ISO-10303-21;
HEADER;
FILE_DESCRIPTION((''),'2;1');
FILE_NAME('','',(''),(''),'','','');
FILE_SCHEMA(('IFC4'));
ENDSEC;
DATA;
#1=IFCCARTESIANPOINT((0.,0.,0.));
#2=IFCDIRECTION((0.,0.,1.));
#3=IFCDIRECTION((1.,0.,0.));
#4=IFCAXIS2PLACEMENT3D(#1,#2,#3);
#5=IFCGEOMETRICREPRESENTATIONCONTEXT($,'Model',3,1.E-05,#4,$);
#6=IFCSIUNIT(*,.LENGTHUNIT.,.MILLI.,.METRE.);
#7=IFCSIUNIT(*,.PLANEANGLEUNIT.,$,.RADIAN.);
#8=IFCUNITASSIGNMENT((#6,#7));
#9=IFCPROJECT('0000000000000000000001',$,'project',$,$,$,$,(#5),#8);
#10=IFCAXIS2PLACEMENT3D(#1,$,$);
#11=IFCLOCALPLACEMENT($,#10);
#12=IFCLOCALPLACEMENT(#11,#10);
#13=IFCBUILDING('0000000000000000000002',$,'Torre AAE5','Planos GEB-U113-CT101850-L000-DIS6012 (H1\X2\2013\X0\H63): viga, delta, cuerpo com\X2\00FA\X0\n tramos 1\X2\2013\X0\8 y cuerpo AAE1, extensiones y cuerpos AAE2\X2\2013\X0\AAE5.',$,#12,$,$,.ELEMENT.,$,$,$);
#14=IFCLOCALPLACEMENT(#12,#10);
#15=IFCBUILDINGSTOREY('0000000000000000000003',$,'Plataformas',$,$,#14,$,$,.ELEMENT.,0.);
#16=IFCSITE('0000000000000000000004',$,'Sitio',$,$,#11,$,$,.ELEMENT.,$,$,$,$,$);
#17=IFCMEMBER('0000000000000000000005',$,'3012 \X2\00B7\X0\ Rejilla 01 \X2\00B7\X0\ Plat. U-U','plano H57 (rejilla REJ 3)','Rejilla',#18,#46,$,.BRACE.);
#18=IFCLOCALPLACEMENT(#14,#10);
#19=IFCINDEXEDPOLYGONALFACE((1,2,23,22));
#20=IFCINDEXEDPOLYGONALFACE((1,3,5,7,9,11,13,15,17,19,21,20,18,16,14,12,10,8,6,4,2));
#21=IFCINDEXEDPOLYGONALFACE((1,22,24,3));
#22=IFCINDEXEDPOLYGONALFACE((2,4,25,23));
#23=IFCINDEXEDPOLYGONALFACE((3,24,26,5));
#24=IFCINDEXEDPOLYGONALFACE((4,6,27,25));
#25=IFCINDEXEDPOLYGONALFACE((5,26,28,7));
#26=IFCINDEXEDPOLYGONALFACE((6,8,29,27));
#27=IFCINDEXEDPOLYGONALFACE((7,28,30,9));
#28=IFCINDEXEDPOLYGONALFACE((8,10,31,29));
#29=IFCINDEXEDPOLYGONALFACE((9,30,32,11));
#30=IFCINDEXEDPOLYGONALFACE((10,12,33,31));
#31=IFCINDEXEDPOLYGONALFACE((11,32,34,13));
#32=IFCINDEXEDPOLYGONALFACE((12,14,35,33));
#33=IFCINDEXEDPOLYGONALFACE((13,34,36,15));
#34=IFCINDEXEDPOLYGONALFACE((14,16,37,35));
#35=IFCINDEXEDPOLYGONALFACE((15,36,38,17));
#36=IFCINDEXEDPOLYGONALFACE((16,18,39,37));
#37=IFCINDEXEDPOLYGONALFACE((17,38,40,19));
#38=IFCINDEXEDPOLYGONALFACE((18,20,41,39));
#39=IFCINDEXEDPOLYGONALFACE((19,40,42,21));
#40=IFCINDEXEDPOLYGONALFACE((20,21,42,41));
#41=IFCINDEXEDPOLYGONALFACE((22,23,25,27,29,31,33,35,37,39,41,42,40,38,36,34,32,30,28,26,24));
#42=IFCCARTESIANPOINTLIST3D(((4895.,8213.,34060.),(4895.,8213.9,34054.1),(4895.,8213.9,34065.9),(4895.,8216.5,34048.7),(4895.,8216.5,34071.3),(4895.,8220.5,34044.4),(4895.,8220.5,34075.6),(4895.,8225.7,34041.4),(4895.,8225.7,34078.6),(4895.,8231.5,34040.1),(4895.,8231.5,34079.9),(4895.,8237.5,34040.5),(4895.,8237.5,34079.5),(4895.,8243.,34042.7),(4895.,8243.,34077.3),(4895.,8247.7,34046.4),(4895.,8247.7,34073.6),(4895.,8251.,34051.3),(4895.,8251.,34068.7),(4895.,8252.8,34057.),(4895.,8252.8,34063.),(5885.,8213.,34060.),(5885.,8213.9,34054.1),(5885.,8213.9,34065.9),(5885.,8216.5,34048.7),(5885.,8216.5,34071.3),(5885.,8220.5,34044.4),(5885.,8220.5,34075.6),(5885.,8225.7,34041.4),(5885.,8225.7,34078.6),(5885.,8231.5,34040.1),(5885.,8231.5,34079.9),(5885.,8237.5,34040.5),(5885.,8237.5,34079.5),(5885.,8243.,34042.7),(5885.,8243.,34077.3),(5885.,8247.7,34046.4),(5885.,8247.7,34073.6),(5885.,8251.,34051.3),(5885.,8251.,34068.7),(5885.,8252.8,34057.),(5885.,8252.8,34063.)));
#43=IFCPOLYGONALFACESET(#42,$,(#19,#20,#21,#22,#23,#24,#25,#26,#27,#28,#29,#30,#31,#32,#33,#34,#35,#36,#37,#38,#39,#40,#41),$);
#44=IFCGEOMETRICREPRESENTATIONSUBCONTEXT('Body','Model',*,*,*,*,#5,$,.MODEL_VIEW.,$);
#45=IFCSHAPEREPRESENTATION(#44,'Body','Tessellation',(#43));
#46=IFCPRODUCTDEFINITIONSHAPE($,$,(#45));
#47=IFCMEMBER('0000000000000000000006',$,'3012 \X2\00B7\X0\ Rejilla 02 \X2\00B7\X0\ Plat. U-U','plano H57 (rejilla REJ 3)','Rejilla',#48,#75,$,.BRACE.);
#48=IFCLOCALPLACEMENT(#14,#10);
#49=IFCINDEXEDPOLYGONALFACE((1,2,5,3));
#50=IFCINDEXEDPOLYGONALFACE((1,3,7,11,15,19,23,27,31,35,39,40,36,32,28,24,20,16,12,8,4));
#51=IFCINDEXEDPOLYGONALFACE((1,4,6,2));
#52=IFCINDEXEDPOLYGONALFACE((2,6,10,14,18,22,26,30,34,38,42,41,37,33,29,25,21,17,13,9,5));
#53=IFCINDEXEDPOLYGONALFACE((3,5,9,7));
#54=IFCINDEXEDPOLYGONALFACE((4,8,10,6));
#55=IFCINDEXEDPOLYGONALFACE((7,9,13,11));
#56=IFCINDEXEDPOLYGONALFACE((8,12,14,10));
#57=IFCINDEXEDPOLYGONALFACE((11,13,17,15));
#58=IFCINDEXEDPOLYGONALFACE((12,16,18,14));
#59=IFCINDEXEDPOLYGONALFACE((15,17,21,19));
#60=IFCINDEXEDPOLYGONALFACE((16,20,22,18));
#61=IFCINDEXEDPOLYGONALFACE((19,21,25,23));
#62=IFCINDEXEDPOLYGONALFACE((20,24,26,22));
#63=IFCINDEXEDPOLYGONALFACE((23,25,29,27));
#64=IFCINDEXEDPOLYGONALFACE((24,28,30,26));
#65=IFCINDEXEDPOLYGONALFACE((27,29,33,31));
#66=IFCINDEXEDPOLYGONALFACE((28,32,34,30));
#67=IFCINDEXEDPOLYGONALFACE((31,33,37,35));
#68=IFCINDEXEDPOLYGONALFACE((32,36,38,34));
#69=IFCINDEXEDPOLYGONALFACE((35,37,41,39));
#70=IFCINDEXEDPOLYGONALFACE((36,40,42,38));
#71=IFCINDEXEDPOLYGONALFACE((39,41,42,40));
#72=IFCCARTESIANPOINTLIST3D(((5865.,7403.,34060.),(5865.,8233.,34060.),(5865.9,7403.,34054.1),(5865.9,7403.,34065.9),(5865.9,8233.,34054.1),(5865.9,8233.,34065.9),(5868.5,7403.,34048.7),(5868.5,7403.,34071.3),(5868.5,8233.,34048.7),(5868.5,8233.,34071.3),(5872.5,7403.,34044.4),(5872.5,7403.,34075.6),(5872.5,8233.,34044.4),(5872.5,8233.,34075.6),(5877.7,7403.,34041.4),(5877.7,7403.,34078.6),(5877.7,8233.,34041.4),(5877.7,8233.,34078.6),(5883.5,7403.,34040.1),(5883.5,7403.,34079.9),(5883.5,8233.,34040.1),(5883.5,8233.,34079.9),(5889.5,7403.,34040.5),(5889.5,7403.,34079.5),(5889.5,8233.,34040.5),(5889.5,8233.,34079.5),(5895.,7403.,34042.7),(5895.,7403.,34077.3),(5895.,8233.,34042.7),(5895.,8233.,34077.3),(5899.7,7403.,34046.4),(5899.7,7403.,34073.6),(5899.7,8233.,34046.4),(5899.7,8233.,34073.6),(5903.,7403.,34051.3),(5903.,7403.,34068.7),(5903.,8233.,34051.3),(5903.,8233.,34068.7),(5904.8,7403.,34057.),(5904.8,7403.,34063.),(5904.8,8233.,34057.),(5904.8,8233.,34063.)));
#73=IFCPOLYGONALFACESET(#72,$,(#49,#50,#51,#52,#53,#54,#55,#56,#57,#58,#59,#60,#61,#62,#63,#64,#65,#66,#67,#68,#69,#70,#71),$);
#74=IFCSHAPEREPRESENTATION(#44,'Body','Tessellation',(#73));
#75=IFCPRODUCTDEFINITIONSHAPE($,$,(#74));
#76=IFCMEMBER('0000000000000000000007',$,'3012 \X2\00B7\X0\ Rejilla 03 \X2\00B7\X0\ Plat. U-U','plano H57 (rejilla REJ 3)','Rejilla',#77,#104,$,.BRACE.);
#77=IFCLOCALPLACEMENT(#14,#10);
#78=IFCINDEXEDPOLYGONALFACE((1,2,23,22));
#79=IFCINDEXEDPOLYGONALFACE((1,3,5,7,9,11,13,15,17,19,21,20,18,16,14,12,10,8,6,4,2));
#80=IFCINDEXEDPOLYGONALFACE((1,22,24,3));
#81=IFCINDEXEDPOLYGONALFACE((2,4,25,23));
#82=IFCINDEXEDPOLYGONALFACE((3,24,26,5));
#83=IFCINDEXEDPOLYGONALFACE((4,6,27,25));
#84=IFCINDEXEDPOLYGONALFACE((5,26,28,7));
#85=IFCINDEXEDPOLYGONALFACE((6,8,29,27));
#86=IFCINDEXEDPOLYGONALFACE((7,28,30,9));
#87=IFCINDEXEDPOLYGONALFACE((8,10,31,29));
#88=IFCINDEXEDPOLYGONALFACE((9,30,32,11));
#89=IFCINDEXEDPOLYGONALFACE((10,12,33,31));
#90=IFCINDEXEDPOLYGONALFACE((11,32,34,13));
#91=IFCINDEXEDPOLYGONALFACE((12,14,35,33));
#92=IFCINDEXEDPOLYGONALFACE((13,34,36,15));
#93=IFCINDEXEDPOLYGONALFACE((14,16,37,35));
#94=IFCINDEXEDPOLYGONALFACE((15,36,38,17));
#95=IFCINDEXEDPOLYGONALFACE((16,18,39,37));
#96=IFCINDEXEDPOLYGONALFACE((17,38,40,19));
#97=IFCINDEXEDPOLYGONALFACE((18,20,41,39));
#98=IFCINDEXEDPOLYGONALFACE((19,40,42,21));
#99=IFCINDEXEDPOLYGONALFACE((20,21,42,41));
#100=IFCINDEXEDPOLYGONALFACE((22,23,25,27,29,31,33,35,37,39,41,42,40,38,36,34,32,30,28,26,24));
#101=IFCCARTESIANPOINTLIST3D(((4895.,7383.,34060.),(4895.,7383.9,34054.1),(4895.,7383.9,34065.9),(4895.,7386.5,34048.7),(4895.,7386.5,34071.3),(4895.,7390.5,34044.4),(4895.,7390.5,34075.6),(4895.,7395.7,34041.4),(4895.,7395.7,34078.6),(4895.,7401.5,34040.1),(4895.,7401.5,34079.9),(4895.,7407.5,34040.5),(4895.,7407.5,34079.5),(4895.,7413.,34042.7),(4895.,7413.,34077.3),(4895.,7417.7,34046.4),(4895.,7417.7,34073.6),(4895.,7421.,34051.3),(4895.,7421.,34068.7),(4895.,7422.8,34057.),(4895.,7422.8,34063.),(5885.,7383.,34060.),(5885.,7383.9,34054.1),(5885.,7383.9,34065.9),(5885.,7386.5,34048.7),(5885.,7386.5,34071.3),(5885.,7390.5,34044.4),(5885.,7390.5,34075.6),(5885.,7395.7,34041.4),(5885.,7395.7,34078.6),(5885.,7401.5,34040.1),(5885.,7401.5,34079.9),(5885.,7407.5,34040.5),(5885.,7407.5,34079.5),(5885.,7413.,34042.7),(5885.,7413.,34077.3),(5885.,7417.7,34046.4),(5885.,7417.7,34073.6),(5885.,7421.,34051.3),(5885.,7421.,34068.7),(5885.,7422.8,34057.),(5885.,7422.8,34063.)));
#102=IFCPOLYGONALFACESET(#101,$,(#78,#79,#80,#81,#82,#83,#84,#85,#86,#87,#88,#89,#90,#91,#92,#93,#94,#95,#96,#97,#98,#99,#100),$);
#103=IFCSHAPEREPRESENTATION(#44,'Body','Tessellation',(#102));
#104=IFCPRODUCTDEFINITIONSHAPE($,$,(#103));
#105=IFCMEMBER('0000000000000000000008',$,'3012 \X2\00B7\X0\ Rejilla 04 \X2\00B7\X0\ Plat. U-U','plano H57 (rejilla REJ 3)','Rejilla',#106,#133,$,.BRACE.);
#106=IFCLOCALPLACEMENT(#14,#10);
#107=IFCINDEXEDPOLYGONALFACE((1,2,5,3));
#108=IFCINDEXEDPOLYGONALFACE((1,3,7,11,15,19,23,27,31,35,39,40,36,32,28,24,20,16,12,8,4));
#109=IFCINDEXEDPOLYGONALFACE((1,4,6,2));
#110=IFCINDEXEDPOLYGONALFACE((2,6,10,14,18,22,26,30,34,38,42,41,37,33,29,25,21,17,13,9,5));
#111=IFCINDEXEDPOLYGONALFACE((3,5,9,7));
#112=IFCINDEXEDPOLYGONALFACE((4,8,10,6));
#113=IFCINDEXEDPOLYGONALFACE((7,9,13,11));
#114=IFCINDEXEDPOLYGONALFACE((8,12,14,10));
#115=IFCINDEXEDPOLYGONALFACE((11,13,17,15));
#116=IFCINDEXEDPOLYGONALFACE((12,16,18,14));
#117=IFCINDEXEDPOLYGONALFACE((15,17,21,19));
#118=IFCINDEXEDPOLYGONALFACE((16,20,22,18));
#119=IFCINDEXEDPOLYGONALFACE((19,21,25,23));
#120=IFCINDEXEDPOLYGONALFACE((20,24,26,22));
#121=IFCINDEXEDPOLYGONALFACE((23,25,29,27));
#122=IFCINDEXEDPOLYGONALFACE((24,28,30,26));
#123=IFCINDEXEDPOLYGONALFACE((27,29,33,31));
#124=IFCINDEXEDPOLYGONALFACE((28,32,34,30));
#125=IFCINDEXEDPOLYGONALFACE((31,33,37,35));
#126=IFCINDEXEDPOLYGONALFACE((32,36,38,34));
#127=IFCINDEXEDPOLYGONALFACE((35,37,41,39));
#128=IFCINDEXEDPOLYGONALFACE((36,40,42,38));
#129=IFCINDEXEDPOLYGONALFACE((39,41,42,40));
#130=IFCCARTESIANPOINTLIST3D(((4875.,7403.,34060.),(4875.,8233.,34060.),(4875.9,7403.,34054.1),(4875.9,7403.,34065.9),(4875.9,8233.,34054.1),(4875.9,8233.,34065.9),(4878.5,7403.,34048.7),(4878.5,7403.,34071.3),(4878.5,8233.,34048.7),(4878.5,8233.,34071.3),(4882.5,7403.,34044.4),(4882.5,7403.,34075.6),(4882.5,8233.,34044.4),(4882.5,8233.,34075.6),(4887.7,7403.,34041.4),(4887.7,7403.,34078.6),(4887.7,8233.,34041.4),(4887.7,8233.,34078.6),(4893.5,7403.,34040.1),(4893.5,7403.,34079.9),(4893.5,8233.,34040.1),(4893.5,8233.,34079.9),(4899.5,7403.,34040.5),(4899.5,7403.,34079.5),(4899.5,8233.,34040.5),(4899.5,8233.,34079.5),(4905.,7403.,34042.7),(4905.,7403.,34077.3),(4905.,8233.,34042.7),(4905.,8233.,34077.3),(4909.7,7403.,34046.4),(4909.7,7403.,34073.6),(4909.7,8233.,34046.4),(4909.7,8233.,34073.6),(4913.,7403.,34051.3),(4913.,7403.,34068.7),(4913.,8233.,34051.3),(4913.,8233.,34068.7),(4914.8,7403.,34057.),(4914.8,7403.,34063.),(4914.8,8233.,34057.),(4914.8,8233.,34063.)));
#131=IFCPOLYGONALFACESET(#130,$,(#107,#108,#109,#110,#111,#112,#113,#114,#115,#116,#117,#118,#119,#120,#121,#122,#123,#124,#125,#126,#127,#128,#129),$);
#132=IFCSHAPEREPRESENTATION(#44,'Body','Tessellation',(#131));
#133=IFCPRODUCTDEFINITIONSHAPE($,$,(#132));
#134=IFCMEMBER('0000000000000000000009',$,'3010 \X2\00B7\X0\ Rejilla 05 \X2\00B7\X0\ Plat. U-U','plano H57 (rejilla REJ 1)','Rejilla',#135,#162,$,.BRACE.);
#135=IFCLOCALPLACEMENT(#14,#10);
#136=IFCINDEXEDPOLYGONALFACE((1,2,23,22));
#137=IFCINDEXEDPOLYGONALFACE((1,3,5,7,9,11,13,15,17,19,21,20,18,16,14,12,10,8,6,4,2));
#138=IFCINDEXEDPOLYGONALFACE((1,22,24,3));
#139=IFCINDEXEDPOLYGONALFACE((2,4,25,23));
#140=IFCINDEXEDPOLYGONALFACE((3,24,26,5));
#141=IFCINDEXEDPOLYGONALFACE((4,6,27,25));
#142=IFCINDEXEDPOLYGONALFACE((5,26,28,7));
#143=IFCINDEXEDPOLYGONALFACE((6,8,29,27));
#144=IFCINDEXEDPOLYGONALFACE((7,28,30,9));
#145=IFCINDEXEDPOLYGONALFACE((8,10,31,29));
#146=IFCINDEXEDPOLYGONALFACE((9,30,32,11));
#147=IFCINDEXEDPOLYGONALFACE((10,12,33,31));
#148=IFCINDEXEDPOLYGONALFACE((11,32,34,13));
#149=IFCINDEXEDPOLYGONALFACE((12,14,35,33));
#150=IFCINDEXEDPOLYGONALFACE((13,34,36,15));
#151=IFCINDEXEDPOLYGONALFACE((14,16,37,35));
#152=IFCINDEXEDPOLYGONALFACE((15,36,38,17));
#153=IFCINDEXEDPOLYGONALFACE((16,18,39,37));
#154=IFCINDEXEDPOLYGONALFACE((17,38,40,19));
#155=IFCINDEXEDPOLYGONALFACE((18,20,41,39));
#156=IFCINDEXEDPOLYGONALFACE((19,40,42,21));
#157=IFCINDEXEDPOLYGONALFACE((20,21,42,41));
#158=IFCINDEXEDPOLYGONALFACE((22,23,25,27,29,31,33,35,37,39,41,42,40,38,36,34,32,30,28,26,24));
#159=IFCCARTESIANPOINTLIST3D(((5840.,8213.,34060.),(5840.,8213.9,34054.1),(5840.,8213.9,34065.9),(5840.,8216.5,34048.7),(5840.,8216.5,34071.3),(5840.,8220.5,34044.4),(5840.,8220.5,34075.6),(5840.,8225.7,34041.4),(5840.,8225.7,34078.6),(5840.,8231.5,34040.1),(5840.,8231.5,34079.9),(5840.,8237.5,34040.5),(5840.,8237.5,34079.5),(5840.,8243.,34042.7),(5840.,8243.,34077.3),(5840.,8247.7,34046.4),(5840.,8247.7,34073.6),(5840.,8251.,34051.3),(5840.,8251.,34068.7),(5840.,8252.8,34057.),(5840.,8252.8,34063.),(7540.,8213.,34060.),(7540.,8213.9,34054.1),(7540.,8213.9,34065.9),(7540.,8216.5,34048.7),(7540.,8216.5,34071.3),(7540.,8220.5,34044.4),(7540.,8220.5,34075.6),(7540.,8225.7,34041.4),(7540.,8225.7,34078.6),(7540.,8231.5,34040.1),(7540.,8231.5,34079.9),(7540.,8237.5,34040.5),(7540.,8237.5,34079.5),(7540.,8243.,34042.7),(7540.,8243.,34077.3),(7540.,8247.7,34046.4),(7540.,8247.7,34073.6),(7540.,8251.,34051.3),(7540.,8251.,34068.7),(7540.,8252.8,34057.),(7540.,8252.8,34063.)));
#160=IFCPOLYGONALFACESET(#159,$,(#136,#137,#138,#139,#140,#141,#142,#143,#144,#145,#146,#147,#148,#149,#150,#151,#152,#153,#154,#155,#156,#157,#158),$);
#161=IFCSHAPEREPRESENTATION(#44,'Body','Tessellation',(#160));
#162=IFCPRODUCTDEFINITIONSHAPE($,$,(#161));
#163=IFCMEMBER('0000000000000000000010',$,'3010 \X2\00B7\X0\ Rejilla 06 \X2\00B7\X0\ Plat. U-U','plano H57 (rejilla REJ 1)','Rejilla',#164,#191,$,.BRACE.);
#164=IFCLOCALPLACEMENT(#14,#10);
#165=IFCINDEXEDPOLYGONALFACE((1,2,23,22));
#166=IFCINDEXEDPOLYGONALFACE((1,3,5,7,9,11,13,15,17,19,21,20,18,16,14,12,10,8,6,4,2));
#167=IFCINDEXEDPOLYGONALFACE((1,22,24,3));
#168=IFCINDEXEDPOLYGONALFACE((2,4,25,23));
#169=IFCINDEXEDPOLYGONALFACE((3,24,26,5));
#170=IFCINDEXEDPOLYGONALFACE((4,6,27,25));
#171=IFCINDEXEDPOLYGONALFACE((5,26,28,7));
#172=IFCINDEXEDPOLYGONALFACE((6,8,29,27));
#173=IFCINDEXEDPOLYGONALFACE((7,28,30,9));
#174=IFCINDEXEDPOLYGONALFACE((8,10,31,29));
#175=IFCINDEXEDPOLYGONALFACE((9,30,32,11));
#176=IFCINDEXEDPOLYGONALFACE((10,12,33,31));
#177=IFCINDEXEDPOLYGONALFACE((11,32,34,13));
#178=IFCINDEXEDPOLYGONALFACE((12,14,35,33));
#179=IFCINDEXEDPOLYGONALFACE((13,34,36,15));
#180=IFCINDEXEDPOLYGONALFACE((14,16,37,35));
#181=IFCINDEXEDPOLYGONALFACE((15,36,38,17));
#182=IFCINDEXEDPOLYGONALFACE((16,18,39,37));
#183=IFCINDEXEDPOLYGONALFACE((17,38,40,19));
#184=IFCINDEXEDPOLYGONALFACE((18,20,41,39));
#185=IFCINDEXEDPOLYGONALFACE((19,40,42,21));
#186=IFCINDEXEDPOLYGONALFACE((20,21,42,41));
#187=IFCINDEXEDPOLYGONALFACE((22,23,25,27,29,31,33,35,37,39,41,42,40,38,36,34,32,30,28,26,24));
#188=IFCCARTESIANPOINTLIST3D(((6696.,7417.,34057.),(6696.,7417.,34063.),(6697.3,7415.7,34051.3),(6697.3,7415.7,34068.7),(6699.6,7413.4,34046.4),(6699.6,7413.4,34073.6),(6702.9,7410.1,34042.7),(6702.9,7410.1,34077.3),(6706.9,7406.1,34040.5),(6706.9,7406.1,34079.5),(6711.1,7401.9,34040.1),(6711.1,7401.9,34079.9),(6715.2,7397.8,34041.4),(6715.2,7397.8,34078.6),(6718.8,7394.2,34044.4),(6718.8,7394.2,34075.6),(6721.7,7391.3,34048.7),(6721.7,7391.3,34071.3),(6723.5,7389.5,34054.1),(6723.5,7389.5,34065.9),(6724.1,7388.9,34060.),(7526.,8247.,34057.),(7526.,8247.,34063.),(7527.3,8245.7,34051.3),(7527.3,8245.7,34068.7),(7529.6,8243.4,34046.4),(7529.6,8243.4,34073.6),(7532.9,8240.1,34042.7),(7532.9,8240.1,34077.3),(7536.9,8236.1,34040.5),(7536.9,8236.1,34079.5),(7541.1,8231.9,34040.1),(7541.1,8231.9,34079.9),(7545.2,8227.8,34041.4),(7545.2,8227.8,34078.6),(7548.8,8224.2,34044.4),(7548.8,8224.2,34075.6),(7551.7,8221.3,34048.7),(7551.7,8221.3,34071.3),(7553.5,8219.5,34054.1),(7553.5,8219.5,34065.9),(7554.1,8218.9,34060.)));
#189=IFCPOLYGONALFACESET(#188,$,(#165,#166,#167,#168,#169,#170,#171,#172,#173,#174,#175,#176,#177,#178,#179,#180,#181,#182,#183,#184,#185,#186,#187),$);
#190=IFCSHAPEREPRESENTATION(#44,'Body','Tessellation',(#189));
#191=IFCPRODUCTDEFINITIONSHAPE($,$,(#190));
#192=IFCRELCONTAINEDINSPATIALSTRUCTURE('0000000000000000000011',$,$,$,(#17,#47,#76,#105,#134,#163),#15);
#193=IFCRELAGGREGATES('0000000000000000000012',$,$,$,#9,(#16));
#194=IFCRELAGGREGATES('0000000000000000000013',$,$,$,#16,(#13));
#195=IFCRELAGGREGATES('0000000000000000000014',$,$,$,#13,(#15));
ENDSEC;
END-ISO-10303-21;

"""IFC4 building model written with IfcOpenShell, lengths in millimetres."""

from ifc_helpers import new_model, si_unit, frame, origin, origin_with_axes, place, context, subcontext, project, spatial, circle, extrude, element, save


model = new_model("IFC4")

# Units and contexts
model_context = context("Model", 3, precision=1e-05, world=origin_with_axes())
body_context = subcontext(model_context, "Body", "Model", "MODEL_VIEW")
ifc_project = project(units=[si_unit("LENGTHUNIT", "METRE", prefix="MILLI"), si_unit("PLANEANGLEUNIT", "RADIAN")], contexts=[model_context])

# Site, building, storey
site_placement = place(None, origin())
site = spatial("IfcSite", under=ifc_project, at=site_placement, Name="Sitio", CompositionType="ELEMENT")
building_placement = place(site_placement, origin())
building = spatial("IfcBuilding", under=site, at=building_placement, Name="Torre AAE5", Description="Planos GEB-U113-CT101850-L000-DIS6012 (H1–H63): viga, delta, cuerpo común tramos 1–8 y cuerpo AAE1, extensiones y cuerpos AAE2–AAE5.", CompositionType="ELEMENT")
storey_placement = place(building_placement, origin())
storey = spatial("IfcBuildingStorey", under=building, at=storey_placement, Name="Plataformas", CompositionType="ELEMENT", Elevation=0.0)

# Members
member_1_placement = place(storey_placement, frame((4895.0, 8233.0, 34060.0), z_axis=(1.0, 0.0, 0.0), x_axis=(0.0, -1.0, 0.0)))
element("IfcMember", 1, at=member_1_placement, inside=storey, Name="3012 · Rejilla 01 · Plat. U-U", Description="plano H57 (rejilla REJ 3)", ObjectType="Rejilla", PredefinedType="BRACE", context=body_context, shape_type="SweptSolid", body=[
    extrude(circle(Radius=20.0), None, (0.0, 0.0, 1.0), 990.0),
])
member_2_placement = place(storey_placement, frame((5885.0, 8233.0, 34060.0), z_axis=(0.0, -1.0, 0.0), x_axis=(-1.0, 0.0, 0.0)))
element("IfcMember", 2, at=member_2_placement, inside=storey, Name="3012 · Rejilla 02 · Plat. U-U", Description="plano H57 (rejilla REJ 3)", ObjectType="Rejilla", PredefinedType="BRACE", context=body_context, shape_type="SweptSolid", body=[
    extrude(circle(Radius=20.0), None, (0.0, 0.0, 1.0), 830.0),
])
member_3_placement = place(storey_placement, frame((5885.0, 7403.0, 34060.0), z_axis=(-1.0, 0.0, 0.0), x_axis=(0.0, -1.0, 0.0)))
element("IfcMember", 3, at=member_3_placement, inside=storey, Name="3012 · Rejilla 03 · Plat. U-U", Description="plano H57 (rejilla REJ 3)", ObjectType="Rejilla", PredefinedType="BRACE", context=body_context, shape_type="SweptSolid", body=[
    extrude(circle(Radius=20.0), None, (0.0, 0.0, 1.0), 990.0),
])
member_4_placement = place(storey_placement, frame((4895.0, 7403.0, 34060.0), z_axis=(0.0, 1.0, 0.0), x_axis=(-1.0, 0.0, 0.0)))
element("IfcMember", 4, at=member_4_placement, inside=storey, Name="3012 · Rejilla 04 · Plat. U-U", Description="plano H57 (rejilla REJ 3)", ObjectType="Rejilla", PredefinedType="BRACE", context=body_context, shape_type="SweptSolid", body=[
    extrude(circle(Radius=20.0), None, (0.0, 0.0, 1.0), 830.0),
])
member_5_placement = place(storey_placement, frame((5840.0, 8233.0, 34060.0), z_axis=(1.0, 0.0, 0.0), x_axis=(0.0, -1.0, 0.0)))
element("IfcMember", 5, at=member_5_placement, inside=storey, Name="3010 · Rejilla 05 · Plat. U-U", Description="plano H57 (rejilla REJ 1)", ObjectType="Rejilla", PredefinedType="BRACE", context=body_context, shape_type="SweptSolid", body=[
    extrude(circle(Radius=20.0), None, (0.0, 0.0, 1.0), 1700.0),
])
member_6_placement = place(storey_placement, frame((7540.0, 8233.0, 34060.0), z_axis=(-0.707107, -0.707107, 0.0), x_axis=(0.707107, -0.707107, 0.0)))
element("IfcMember", 6, at=member_6_placement, inside=storey, Name="3010 · Rejilla 06 · Plat. U-U", Description="plano H57 (rejilla REJ 1)", ObjectType="Rejilla", PredefinedType="BRACE", context=body_context, shape_type="SweptSolid", body=[
    extrude(circle(Radius=20.0), None, (0.0, 0.0, 1.0), 1173.8),
])

save(model, "model.ifc")
